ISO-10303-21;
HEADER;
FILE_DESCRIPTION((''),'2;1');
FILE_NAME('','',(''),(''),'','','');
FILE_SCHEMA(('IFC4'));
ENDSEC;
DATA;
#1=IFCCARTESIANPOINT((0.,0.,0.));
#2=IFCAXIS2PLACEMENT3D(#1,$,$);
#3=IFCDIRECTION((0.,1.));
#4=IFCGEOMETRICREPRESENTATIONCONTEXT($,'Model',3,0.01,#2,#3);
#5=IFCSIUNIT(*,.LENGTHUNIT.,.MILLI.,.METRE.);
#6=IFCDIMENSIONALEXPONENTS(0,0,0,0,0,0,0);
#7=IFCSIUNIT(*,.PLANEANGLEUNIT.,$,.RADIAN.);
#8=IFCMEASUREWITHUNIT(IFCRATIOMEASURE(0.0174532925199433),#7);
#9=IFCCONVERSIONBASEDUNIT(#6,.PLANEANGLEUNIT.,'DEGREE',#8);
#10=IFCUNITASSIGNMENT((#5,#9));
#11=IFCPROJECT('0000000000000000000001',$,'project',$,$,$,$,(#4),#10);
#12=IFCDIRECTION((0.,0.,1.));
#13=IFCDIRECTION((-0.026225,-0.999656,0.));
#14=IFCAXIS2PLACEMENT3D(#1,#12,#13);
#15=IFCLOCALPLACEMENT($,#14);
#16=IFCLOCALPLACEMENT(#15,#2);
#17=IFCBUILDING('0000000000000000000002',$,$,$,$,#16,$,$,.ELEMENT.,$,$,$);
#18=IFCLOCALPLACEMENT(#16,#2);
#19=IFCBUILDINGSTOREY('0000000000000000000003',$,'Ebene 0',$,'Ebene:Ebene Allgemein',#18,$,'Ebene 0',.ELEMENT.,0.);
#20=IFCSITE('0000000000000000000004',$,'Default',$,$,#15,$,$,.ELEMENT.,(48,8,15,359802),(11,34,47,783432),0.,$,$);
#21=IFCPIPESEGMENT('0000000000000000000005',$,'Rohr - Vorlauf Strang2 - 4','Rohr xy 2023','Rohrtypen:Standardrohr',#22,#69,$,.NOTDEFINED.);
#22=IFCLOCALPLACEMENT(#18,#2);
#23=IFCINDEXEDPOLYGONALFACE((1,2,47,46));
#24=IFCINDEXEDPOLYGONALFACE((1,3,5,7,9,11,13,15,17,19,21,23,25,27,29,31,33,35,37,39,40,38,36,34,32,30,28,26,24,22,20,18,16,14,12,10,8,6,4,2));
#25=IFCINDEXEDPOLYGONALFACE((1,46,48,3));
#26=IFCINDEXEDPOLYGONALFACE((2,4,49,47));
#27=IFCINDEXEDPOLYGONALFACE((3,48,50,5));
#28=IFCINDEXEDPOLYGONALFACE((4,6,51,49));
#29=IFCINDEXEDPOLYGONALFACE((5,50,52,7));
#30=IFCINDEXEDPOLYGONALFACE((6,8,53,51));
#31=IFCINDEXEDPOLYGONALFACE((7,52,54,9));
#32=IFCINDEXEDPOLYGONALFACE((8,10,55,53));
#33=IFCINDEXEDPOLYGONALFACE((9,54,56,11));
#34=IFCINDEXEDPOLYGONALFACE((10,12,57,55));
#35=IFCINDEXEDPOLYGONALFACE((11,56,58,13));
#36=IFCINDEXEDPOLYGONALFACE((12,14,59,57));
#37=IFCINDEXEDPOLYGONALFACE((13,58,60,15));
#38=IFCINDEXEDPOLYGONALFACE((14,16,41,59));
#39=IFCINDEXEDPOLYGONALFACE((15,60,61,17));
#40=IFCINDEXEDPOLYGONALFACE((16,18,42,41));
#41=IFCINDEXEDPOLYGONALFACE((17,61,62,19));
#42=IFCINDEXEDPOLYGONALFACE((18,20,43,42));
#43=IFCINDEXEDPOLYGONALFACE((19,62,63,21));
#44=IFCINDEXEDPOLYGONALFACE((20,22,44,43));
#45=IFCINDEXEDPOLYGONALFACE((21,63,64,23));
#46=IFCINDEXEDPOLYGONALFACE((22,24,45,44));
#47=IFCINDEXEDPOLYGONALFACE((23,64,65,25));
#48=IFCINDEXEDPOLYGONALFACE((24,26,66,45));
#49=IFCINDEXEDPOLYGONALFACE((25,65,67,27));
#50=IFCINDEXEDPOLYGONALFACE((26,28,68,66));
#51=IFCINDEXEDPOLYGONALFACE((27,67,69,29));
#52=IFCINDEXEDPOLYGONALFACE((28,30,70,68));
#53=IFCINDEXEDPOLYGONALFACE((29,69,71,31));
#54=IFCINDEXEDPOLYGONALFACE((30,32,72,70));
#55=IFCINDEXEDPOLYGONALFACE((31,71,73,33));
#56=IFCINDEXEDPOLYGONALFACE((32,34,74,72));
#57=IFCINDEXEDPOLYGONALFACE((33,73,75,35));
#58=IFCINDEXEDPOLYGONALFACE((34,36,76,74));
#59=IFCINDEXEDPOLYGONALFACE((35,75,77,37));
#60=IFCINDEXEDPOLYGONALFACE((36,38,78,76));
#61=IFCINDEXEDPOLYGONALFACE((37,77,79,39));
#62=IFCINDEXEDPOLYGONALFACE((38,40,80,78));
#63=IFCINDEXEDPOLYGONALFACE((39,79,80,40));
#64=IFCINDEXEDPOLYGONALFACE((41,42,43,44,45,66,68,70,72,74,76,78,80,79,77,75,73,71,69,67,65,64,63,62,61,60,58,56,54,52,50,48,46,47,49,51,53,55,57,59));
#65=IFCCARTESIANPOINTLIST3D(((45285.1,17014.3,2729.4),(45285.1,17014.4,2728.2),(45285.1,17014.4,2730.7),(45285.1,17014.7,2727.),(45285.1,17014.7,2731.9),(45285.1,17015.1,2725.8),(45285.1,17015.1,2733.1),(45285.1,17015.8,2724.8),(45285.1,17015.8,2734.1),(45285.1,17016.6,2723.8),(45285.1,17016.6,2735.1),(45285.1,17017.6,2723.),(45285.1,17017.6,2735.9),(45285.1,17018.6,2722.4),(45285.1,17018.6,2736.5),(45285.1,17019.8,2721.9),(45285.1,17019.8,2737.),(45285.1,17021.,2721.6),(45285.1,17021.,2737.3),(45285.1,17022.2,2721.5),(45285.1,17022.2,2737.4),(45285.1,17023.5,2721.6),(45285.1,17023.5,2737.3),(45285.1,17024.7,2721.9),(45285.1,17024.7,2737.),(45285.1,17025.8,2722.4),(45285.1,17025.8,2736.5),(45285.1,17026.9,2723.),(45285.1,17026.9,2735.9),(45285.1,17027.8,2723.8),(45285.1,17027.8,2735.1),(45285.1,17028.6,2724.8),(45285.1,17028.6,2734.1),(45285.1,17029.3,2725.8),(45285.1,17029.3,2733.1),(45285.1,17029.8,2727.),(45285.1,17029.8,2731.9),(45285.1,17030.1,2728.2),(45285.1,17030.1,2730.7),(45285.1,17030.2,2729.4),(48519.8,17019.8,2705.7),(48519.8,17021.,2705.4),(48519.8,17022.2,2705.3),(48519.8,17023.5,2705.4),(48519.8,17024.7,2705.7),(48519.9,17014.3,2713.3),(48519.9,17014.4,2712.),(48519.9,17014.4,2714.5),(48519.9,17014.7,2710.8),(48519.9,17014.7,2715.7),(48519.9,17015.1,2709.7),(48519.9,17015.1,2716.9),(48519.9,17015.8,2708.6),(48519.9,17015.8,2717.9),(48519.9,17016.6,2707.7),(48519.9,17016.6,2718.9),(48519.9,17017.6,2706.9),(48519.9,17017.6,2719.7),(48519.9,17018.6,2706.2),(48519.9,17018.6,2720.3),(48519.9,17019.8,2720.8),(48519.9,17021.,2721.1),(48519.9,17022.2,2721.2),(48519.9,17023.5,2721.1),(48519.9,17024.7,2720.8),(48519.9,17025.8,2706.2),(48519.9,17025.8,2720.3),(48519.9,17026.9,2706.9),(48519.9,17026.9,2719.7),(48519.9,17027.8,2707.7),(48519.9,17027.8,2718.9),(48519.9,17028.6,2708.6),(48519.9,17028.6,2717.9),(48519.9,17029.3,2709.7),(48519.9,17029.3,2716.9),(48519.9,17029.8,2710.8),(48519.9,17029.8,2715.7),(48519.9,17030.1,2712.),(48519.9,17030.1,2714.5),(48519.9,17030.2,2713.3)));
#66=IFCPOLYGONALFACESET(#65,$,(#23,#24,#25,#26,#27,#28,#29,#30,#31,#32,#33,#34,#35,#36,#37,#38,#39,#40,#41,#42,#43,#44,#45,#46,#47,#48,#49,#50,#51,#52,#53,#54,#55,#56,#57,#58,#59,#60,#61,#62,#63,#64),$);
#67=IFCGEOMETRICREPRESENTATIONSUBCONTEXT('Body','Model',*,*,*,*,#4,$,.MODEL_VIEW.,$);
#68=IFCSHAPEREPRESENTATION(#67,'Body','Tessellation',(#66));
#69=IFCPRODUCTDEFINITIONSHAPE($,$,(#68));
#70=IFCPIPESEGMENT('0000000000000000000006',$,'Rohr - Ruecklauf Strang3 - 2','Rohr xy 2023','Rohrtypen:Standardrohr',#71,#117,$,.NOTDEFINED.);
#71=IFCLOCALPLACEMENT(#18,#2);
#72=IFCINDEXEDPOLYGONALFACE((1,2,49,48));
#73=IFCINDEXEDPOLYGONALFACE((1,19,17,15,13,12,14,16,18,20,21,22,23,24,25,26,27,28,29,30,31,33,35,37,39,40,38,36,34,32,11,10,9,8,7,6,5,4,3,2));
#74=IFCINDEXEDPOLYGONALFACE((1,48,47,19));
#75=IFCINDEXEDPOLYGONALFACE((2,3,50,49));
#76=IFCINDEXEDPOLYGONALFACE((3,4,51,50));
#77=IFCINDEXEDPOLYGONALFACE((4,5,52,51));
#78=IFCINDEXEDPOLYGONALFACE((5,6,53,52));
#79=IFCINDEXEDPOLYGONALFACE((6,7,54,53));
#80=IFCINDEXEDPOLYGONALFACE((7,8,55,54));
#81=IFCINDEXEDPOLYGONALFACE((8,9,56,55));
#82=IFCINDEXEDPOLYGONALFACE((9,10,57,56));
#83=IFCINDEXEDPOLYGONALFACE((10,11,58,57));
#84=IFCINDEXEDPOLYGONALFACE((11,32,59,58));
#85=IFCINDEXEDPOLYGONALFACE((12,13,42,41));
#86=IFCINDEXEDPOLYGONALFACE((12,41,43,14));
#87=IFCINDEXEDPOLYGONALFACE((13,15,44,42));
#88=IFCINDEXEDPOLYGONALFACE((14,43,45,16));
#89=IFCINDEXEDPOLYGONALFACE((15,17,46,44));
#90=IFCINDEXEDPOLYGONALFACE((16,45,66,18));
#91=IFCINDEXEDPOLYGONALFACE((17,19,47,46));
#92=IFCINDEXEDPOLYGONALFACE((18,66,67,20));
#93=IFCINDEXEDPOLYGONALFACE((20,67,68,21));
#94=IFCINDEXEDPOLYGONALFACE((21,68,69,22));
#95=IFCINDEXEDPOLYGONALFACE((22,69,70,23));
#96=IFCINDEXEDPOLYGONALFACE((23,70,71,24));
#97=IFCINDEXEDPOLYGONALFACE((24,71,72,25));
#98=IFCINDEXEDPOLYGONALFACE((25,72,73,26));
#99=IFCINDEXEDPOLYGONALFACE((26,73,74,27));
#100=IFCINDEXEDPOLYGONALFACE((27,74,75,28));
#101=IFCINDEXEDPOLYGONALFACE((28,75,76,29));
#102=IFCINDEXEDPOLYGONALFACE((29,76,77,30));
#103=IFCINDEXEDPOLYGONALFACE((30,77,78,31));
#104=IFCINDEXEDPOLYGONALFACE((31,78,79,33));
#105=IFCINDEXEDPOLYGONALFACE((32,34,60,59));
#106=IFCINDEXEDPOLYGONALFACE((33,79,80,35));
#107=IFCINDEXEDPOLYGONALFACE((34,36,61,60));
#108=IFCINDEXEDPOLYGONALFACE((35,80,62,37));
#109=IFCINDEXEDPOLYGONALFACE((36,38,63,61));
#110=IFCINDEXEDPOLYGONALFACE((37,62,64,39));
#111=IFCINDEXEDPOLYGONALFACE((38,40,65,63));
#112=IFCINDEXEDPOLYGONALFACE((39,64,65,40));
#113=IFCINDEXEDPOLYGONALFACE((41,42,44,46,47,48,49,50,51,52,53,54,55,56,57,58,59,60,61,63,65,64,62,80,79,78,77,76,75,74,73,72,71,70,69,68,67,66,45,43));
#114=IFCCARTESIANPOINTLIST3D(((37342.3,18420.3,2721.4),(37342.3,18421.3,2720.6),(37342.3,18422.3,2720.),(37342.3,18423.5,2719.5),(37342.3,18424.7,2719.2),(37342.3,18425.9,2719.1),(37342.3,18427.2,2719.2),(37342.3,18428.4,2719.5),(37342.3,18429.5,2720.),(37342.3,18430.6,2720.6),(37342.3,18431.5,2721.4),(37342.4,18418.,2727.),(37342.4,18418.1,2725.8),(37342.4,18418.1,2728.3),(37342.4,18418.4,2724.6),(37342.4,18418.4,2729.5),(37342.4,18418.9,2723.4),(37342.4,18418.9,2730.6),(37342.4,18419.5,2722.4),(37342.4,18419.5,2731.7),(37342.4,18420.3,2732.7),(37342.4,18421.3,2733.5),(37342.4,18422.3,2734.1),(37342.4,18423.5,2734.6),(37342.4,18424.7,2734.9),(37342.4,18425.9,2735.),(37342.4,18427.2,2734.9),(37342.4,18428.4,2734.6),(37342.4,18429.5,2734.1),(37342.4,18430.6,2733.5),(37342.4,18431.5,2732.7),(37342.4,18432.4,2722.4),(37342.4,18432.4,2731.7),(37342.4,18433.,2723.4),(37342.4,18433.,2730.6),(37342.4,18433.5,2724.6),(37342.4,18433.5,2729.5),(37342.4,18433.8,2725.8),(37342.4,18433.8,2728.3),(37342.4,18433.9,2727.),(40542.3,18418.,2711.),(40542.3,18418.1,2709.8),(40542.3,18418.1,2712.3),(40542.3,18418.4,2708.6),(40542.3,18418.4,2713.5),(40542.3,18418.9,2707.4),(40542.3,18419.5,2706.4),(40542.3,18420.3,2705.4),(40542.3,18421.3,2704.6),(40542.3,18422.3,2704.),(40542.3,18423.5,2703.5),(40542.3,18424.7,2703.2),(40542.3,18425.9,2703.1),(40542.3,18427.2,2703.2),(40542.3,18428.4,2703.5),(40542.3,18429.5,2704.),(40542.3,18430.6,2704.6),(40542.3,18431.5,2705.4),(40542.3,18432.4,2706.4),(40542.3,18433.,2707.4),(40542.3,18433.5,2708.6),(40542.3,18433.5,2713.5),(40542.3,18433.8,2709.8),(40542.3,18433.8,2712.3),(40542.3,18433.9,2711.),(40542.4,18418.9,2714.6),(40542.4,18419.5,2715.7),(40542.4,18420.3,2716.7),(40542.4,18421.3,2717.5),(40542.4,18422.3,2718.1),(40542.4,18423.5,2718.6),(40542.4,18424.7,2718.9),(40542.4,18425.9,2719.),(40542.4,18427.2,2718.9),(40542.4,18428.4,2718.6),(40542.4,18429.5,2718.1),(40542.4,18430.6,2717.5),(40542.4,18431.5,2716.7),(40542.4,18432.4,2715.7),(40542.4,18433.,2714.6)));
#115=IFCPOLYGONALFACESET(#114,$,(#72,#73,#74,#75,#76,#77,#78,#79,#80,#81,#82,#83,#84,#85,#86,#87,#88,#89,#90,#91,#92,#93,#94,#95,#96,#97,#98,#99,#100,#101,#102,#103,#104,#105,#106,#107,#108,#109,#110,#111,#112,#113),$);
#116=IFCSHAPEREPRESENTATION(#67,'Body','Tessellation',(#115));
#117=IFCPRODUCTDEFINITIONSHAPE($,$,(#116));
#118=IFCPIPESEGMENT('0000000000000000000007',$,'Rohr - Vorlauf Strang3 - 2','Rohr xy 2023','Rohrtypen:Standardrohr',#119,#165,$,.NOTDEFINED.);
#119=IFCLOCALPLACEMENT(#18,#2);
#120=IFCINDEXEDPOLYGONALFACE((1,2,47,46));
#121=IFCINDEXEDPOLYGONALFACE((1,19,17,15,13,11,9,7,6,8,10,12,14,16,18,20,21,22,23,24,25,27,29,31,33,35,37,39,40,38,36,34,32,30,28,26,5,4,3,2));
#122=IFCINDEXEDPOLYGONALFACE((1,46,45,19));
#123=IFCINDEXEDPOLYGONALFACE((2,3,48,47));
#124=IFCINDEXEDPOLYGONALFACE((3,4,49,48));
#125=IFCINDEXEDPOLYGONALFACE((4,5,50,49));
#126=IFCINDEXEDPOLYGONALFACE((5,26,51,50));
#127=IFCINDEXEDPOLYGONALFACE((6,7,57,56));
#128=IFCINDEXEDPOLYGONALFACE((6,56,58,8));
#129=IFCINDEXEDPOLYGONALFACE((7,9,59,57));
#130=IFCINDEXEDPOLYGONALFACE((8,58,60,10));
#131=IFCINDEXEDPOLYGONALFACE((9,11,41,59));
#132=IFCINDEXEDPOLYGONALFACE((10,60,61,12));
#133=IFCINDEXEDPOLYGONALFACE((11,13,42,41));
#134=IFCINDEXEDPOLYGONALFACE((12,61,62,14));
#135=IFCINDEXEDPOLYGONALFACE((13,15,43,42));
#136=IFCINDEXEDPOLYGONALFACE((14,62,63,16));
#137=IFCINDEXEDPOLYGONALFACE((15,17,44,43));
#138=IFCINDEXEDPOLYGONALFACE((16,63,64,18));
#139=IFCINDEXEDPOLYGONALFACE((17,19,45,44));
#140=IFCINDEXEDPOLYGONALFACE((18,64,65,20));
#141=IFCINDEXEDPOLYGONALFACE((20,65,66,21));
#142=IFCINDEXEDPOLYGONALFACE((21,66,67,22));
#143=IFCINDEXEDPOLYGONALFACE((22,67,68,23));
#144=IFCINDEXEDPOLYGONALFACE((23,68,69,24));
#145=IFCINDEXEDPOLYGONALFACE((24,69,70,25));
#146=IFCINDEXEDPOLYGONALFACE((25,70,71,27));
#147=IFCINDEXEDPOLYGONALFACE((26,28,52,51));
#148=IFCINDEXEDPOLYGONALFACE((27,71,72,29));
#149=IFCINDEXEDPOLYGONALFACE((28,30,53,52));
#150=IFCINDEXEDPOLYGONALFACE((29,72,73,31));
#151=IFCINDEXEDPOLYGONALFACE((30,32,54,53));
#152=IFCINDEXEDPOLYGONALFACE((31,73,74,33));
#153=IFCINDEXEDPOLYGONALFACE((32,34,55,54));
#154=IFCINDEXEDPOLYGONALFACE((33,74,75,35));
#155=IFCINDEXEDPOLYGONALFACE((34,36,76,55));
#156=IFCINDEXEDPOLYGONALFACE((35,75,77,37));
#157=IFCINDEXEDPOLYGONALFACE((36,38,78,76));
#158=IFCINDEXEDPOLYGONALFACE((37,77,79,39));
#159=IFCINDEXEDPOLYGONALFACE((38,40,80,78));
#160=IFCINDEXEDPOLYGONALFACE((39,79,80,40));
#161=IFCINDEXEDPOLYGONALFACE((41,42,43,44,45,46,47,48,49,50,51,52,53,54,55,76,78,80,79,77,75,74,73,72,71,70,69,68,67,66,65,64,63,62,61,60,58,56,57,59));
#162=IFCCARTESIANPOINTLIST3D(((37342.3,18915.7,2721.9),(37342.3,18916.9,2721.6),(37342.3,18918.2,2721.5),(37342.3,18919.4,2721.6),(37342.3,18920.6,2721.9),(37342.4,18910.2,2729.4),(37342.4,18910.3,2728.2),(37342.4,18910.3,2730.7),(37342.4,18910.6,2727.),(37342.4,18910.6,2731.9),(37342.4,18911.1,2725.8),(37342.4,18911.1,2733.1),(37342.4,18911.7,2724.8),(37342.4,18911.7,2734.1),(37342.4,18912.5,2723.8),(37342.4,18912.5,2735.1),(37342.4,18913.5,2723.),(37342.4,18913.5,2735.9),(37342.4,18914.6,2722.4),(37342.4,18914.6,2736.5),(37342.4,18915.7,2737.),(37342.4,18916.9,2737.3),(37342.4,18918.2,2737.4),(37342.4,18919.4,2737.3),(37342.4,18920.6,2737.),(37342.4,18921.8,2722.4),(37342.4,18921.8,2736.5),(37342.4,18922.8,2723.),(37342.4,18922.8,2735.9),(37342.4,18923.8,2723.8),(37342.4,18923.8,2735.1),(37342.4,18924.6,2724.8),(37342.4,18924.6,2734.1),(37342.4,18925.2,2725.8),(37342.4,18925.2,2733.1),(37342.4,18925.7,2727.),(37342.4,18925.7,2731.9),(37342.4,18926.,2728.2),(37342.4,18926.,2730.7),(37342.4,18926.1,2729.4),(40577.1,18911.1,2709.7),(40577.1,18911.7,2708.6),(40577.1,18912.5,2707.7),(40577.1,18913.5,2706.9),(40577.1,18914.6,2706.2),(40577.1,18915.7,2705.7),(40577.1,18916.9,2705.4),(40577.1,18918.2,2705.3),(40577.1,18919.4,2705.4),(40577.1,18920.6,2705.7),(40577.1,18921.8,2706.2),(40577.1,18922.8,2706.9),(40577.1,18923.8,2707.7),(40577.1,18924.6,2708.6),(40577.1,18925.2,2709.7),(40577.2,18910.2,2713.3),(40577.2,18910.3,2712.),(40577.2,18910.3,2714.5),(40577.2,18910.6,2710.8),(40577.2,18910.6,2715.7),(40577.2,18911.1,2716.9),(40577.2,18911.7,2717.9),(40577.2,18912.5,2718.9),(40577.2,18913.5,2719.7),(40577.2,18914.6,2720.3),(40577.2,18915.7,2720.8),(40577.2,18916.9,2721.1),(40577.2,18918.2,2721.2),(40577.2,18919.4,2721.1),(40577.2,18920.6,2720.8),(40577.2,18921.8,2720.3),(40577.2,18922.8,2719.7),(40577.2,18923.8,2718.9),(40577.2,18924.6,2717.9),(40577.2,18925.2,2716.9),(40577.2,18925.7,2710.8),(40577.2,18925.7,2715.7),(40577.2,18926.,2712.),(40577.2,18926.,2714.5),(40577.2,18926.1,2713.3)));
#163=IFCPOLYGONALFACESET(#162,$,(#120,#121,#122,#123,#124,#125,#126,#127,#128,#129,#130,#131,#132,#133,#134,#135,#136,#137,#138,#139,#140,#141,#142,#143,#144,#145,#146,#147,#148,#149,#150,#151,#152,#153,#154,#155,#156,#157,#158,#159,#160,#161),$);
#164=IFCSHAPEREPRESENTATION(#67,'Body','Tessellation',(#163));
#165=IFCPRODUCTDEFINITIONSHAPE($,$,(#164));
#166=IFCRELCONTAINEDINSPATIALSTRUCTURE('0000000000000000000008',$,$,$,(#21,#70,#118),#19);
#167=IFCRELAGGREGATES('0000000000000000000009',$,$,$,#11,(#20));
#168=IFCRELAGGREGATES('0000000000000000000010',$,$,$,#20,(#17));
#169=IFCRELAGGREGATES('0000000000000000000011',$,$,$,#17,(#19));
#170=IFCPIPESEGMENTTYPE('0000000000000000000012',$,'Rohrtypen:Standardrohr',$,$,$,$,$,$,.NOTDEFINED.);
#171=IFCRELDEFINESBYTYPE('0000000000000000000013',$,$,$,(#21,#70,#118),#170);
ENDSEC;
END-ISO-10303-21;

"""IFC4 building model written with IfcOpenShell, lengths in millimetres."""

from ifc_helpers import new_model, entity, si_unit, converted_unit, direction, frame, origin, place, context, subcontext, project, spatial, indexed_curve, outline, extrude, type_object, element, save


model = new_model("IFC4")

# Units and contexts
model_context = context("Model", 3, precision=0.01, world=origin(), true_north=direction((0.0, 1.0)))
body_context = subcontext(model_context, "Body", "Model", "MODEL_VIEW")
ifc_project = project(units=[si_unit("LENGTHUNIT", "METRE", prefix="MILLI"), converted_unit("PLANEANGLEUNIT", "DEGREE", entity("IfcRatioMeasure", 0.0174532925199433), si_unit("PLANEANGLEUNIT", "RADIAN"), dimensions=[0, 0, 0, 0, 0, 0, 0])], contexts=[model_context])

# Site, building, storey
site_placement = place(None, frame((0.0, 0.0, 0.0), z_axis=(0.0, 0.0, 1.0), x_axis=(-0.026225, -0.999656, 0.0)))
site = spatial("IfcSite", under=ifc_project, at=site_placement, Name="Default", CompositionType="ELEMENT", RefLatitude=(48, 8, 15, 359802), RefLongitude=(11, 34, 47, 783432), RefElevation=0.0)
building_placement = place(site_placement, origin())
building = spatial("IfcBuilding", under=site, at=building_placement, CompositionType="ELEMENT")
storey_placement = place(building_placement, origin())
storey = spatial("IfcBuildingStorey", under=building, at=storey_placement, Name="Ebene 0", ObjectType="Ebene:Ebene Allgemein", LongName="Ebene 0", CompositionType="ELEMENT", Elevation=0.0)

# Pipe segments
pipe_segment_type = type_object("IfcPipeSegmentType", Name="Rohrtypen:Standardrohr", PredefinedType="NOTDEFINED")
pipe_segment_1_placement = place(storey_placement, origin())
element("IfcPipeSegment", 1, at=pipe_segment_1_placement, inside=storey, type_object=pipe_segment_type, Name="Rohr - Vorlauf Strang2 - 4", Description="Rohr xy 2023", ObjectType="Rohrtypen:Standardrohr", PredefinedType="NOTDEFINED", context=body_context, shape_type="SweptSolid", body=[
    extrude(outline(indexed_curve([(7.9, 0.0), (7.8, 1.2), (7.6, 2.5), (7.1, 3.6), (6.4, 4.7), (5.6, 5.6), (4.7, 6.4), (3.6, 7.1), (2.5, 7.6), (1.2, 7.8), (0.0, 7.9), (-1.2, 7.8), (-2.5, 7.6), (-3.6, 7.1), (-4.7, 6.4), (-5.6, 5.6), (-6.4, 4.7), (-7.1, 3.6), (-7.6, 2.5), (-7.8, 1.2), (-7.9, 0.0), (-7.8, -1.2), (-7.6, -2.5), (-7.1, -3.6), (-6.4, -4.7), (-5.6, -5.6), (-4.7, -6.4), (-3.6, -7.1), (-2.5, -7.6), (-1.2, -7.8), (0.0, -7.9), (1.2, -7.8), (2.5, -7.6), (3.6, -7.1), (4.7, -6.4), (5.6, -5.6), (6.4, -4.7), (7.1, -3.6), (7.6, -2.5), (7.8, -1.2), (7.9, 0.0)], self_intersect=False)), frame((48519.9, 17022.2, 2713.3), z_axis=(-0.999988, 0.0, 0.005), x_axis=(0.0, 1.0, 0.0)), (0.0, 0.0, 1.0), 3234.8),
])
pipe_segment_2_placement = place(storey_placement, origin())
element("IfcPipeSegment", 2, at=pipe_segment_2_placement, inside=storey, type_object=pipe_segment_type, Name="Rohr - Ruecklauf Strang3 - 2", Description="Rohr xy 2023", ObjectType="Rohrtypen:Standardrohr", PredefinedType="NOTDEFINED", context=body_context, shape_type="SweptSolid", body=[
    extrude(outline(indexed_curve([(7.9, 0.0), (7.8, 1.2), (7.6, 2.5), (7.1, 3.6), (6.4, 4.7), (5.6, 5.6), (4.7, 6.4), (3.6, 7.1), (2.5, 7.6), (1.2, 7.8), (0.0, 7.9), (-1.2, 7.8), (-2.5, 7.6), (-3.6, 7.1), (-4.7, 6.4), (-5.6, 5.6), (-6.4, 4.7), (-7.1, 3.6), (-7.6, 2.5), (-7.8, 1.2), (-7.9, 0.0), (-7.8, -1.2), (-7.6, -2.5), (-7.1, -3.6), (-6.4, -4.7), (-5.6, -5.6), (-4.7, -6.4), (-3.6, -7.1), (-2.5, -7.6), (-1.2, -7.8), (0.0, -7.9), (1.2, -7.8), (2.5, -7.6), (3.6, -7.1), (4.7, -6.4), (5.6, -5.6), (6.4, -4.7), (7.1, -3.6), (7.6, -2.5), (7.8, -1.2), (7.9, 0.0)], self_intersect=False)), frame((40542.3, 18425.9, 2711.0), z_axis=(-0.999988, 0.0, 0.005), x_axis=(0.0, 1.0, 0.0)), (0.0, 0.0, 1.0), 3200.0),
])
pipe_segment_3_placement = place(storey_placement, origin())
element("IfcPipeSegment", 3, at=pipe_segment_3_placement, inside=storey, type_object=pipe_segment_type, Name="Rohr - Vorlauf Strang3 - 2", Description="Rohr xy 2023", ObjectType="Rohrtypen:Standardrohr", PredefinedType="NOTDEFINED", context=body_context, shape_type="SweptSolid", body=[
    extrude(outline(indexed_curve([(7.9, 0.0), (7.8, 1.2), (7.6, 2.5), (7.1, 3.6), (6.4, 4.7), (5.6, 5.6), (4.7, 6.4), (3.6, 7.1), (2.5, 7.6), (1.2, 7.8), (0.0, 7.9), (-1.2, 7.8), (-2.5, 7.6), (-3.6, 7.1), (-4.7, 6.4), (-5.6, 5.6), (-6.4, 4.7), (-7.1, 3.6), (-7.6, 2.5), (-7.8, 1.2), (-7.9, 0.0), (-7.8, -1.2), (-7.6, -2.5), (-7.1, -3.6), (-6.4, -4.7), (-5.6, -5.6), (-4.7, -6.4), (-3.6, -7.1), (-2.5, -7.6), (-1.2, -7.8), (0.0, -7.9), (1.2, -7.8), (2.5, -7.6), (3.6, -7.1), (4.7, -6.4), (5.6, -5.6), (6.4, -4.7), (7.1, -3.6), (7.6, -2.5), (7.8, -1.2), (7.9, 0.0)], self_intersect=False)), frame((40577.2, 18918.2, 2713.3), z_axis=(-0.999988, 0.0, 0.005), x_axis=(0.0, 1.0, 0.0)), (0.0, 0.0, 1.0), 3234.8),
])

save(model, "model.ifc")
